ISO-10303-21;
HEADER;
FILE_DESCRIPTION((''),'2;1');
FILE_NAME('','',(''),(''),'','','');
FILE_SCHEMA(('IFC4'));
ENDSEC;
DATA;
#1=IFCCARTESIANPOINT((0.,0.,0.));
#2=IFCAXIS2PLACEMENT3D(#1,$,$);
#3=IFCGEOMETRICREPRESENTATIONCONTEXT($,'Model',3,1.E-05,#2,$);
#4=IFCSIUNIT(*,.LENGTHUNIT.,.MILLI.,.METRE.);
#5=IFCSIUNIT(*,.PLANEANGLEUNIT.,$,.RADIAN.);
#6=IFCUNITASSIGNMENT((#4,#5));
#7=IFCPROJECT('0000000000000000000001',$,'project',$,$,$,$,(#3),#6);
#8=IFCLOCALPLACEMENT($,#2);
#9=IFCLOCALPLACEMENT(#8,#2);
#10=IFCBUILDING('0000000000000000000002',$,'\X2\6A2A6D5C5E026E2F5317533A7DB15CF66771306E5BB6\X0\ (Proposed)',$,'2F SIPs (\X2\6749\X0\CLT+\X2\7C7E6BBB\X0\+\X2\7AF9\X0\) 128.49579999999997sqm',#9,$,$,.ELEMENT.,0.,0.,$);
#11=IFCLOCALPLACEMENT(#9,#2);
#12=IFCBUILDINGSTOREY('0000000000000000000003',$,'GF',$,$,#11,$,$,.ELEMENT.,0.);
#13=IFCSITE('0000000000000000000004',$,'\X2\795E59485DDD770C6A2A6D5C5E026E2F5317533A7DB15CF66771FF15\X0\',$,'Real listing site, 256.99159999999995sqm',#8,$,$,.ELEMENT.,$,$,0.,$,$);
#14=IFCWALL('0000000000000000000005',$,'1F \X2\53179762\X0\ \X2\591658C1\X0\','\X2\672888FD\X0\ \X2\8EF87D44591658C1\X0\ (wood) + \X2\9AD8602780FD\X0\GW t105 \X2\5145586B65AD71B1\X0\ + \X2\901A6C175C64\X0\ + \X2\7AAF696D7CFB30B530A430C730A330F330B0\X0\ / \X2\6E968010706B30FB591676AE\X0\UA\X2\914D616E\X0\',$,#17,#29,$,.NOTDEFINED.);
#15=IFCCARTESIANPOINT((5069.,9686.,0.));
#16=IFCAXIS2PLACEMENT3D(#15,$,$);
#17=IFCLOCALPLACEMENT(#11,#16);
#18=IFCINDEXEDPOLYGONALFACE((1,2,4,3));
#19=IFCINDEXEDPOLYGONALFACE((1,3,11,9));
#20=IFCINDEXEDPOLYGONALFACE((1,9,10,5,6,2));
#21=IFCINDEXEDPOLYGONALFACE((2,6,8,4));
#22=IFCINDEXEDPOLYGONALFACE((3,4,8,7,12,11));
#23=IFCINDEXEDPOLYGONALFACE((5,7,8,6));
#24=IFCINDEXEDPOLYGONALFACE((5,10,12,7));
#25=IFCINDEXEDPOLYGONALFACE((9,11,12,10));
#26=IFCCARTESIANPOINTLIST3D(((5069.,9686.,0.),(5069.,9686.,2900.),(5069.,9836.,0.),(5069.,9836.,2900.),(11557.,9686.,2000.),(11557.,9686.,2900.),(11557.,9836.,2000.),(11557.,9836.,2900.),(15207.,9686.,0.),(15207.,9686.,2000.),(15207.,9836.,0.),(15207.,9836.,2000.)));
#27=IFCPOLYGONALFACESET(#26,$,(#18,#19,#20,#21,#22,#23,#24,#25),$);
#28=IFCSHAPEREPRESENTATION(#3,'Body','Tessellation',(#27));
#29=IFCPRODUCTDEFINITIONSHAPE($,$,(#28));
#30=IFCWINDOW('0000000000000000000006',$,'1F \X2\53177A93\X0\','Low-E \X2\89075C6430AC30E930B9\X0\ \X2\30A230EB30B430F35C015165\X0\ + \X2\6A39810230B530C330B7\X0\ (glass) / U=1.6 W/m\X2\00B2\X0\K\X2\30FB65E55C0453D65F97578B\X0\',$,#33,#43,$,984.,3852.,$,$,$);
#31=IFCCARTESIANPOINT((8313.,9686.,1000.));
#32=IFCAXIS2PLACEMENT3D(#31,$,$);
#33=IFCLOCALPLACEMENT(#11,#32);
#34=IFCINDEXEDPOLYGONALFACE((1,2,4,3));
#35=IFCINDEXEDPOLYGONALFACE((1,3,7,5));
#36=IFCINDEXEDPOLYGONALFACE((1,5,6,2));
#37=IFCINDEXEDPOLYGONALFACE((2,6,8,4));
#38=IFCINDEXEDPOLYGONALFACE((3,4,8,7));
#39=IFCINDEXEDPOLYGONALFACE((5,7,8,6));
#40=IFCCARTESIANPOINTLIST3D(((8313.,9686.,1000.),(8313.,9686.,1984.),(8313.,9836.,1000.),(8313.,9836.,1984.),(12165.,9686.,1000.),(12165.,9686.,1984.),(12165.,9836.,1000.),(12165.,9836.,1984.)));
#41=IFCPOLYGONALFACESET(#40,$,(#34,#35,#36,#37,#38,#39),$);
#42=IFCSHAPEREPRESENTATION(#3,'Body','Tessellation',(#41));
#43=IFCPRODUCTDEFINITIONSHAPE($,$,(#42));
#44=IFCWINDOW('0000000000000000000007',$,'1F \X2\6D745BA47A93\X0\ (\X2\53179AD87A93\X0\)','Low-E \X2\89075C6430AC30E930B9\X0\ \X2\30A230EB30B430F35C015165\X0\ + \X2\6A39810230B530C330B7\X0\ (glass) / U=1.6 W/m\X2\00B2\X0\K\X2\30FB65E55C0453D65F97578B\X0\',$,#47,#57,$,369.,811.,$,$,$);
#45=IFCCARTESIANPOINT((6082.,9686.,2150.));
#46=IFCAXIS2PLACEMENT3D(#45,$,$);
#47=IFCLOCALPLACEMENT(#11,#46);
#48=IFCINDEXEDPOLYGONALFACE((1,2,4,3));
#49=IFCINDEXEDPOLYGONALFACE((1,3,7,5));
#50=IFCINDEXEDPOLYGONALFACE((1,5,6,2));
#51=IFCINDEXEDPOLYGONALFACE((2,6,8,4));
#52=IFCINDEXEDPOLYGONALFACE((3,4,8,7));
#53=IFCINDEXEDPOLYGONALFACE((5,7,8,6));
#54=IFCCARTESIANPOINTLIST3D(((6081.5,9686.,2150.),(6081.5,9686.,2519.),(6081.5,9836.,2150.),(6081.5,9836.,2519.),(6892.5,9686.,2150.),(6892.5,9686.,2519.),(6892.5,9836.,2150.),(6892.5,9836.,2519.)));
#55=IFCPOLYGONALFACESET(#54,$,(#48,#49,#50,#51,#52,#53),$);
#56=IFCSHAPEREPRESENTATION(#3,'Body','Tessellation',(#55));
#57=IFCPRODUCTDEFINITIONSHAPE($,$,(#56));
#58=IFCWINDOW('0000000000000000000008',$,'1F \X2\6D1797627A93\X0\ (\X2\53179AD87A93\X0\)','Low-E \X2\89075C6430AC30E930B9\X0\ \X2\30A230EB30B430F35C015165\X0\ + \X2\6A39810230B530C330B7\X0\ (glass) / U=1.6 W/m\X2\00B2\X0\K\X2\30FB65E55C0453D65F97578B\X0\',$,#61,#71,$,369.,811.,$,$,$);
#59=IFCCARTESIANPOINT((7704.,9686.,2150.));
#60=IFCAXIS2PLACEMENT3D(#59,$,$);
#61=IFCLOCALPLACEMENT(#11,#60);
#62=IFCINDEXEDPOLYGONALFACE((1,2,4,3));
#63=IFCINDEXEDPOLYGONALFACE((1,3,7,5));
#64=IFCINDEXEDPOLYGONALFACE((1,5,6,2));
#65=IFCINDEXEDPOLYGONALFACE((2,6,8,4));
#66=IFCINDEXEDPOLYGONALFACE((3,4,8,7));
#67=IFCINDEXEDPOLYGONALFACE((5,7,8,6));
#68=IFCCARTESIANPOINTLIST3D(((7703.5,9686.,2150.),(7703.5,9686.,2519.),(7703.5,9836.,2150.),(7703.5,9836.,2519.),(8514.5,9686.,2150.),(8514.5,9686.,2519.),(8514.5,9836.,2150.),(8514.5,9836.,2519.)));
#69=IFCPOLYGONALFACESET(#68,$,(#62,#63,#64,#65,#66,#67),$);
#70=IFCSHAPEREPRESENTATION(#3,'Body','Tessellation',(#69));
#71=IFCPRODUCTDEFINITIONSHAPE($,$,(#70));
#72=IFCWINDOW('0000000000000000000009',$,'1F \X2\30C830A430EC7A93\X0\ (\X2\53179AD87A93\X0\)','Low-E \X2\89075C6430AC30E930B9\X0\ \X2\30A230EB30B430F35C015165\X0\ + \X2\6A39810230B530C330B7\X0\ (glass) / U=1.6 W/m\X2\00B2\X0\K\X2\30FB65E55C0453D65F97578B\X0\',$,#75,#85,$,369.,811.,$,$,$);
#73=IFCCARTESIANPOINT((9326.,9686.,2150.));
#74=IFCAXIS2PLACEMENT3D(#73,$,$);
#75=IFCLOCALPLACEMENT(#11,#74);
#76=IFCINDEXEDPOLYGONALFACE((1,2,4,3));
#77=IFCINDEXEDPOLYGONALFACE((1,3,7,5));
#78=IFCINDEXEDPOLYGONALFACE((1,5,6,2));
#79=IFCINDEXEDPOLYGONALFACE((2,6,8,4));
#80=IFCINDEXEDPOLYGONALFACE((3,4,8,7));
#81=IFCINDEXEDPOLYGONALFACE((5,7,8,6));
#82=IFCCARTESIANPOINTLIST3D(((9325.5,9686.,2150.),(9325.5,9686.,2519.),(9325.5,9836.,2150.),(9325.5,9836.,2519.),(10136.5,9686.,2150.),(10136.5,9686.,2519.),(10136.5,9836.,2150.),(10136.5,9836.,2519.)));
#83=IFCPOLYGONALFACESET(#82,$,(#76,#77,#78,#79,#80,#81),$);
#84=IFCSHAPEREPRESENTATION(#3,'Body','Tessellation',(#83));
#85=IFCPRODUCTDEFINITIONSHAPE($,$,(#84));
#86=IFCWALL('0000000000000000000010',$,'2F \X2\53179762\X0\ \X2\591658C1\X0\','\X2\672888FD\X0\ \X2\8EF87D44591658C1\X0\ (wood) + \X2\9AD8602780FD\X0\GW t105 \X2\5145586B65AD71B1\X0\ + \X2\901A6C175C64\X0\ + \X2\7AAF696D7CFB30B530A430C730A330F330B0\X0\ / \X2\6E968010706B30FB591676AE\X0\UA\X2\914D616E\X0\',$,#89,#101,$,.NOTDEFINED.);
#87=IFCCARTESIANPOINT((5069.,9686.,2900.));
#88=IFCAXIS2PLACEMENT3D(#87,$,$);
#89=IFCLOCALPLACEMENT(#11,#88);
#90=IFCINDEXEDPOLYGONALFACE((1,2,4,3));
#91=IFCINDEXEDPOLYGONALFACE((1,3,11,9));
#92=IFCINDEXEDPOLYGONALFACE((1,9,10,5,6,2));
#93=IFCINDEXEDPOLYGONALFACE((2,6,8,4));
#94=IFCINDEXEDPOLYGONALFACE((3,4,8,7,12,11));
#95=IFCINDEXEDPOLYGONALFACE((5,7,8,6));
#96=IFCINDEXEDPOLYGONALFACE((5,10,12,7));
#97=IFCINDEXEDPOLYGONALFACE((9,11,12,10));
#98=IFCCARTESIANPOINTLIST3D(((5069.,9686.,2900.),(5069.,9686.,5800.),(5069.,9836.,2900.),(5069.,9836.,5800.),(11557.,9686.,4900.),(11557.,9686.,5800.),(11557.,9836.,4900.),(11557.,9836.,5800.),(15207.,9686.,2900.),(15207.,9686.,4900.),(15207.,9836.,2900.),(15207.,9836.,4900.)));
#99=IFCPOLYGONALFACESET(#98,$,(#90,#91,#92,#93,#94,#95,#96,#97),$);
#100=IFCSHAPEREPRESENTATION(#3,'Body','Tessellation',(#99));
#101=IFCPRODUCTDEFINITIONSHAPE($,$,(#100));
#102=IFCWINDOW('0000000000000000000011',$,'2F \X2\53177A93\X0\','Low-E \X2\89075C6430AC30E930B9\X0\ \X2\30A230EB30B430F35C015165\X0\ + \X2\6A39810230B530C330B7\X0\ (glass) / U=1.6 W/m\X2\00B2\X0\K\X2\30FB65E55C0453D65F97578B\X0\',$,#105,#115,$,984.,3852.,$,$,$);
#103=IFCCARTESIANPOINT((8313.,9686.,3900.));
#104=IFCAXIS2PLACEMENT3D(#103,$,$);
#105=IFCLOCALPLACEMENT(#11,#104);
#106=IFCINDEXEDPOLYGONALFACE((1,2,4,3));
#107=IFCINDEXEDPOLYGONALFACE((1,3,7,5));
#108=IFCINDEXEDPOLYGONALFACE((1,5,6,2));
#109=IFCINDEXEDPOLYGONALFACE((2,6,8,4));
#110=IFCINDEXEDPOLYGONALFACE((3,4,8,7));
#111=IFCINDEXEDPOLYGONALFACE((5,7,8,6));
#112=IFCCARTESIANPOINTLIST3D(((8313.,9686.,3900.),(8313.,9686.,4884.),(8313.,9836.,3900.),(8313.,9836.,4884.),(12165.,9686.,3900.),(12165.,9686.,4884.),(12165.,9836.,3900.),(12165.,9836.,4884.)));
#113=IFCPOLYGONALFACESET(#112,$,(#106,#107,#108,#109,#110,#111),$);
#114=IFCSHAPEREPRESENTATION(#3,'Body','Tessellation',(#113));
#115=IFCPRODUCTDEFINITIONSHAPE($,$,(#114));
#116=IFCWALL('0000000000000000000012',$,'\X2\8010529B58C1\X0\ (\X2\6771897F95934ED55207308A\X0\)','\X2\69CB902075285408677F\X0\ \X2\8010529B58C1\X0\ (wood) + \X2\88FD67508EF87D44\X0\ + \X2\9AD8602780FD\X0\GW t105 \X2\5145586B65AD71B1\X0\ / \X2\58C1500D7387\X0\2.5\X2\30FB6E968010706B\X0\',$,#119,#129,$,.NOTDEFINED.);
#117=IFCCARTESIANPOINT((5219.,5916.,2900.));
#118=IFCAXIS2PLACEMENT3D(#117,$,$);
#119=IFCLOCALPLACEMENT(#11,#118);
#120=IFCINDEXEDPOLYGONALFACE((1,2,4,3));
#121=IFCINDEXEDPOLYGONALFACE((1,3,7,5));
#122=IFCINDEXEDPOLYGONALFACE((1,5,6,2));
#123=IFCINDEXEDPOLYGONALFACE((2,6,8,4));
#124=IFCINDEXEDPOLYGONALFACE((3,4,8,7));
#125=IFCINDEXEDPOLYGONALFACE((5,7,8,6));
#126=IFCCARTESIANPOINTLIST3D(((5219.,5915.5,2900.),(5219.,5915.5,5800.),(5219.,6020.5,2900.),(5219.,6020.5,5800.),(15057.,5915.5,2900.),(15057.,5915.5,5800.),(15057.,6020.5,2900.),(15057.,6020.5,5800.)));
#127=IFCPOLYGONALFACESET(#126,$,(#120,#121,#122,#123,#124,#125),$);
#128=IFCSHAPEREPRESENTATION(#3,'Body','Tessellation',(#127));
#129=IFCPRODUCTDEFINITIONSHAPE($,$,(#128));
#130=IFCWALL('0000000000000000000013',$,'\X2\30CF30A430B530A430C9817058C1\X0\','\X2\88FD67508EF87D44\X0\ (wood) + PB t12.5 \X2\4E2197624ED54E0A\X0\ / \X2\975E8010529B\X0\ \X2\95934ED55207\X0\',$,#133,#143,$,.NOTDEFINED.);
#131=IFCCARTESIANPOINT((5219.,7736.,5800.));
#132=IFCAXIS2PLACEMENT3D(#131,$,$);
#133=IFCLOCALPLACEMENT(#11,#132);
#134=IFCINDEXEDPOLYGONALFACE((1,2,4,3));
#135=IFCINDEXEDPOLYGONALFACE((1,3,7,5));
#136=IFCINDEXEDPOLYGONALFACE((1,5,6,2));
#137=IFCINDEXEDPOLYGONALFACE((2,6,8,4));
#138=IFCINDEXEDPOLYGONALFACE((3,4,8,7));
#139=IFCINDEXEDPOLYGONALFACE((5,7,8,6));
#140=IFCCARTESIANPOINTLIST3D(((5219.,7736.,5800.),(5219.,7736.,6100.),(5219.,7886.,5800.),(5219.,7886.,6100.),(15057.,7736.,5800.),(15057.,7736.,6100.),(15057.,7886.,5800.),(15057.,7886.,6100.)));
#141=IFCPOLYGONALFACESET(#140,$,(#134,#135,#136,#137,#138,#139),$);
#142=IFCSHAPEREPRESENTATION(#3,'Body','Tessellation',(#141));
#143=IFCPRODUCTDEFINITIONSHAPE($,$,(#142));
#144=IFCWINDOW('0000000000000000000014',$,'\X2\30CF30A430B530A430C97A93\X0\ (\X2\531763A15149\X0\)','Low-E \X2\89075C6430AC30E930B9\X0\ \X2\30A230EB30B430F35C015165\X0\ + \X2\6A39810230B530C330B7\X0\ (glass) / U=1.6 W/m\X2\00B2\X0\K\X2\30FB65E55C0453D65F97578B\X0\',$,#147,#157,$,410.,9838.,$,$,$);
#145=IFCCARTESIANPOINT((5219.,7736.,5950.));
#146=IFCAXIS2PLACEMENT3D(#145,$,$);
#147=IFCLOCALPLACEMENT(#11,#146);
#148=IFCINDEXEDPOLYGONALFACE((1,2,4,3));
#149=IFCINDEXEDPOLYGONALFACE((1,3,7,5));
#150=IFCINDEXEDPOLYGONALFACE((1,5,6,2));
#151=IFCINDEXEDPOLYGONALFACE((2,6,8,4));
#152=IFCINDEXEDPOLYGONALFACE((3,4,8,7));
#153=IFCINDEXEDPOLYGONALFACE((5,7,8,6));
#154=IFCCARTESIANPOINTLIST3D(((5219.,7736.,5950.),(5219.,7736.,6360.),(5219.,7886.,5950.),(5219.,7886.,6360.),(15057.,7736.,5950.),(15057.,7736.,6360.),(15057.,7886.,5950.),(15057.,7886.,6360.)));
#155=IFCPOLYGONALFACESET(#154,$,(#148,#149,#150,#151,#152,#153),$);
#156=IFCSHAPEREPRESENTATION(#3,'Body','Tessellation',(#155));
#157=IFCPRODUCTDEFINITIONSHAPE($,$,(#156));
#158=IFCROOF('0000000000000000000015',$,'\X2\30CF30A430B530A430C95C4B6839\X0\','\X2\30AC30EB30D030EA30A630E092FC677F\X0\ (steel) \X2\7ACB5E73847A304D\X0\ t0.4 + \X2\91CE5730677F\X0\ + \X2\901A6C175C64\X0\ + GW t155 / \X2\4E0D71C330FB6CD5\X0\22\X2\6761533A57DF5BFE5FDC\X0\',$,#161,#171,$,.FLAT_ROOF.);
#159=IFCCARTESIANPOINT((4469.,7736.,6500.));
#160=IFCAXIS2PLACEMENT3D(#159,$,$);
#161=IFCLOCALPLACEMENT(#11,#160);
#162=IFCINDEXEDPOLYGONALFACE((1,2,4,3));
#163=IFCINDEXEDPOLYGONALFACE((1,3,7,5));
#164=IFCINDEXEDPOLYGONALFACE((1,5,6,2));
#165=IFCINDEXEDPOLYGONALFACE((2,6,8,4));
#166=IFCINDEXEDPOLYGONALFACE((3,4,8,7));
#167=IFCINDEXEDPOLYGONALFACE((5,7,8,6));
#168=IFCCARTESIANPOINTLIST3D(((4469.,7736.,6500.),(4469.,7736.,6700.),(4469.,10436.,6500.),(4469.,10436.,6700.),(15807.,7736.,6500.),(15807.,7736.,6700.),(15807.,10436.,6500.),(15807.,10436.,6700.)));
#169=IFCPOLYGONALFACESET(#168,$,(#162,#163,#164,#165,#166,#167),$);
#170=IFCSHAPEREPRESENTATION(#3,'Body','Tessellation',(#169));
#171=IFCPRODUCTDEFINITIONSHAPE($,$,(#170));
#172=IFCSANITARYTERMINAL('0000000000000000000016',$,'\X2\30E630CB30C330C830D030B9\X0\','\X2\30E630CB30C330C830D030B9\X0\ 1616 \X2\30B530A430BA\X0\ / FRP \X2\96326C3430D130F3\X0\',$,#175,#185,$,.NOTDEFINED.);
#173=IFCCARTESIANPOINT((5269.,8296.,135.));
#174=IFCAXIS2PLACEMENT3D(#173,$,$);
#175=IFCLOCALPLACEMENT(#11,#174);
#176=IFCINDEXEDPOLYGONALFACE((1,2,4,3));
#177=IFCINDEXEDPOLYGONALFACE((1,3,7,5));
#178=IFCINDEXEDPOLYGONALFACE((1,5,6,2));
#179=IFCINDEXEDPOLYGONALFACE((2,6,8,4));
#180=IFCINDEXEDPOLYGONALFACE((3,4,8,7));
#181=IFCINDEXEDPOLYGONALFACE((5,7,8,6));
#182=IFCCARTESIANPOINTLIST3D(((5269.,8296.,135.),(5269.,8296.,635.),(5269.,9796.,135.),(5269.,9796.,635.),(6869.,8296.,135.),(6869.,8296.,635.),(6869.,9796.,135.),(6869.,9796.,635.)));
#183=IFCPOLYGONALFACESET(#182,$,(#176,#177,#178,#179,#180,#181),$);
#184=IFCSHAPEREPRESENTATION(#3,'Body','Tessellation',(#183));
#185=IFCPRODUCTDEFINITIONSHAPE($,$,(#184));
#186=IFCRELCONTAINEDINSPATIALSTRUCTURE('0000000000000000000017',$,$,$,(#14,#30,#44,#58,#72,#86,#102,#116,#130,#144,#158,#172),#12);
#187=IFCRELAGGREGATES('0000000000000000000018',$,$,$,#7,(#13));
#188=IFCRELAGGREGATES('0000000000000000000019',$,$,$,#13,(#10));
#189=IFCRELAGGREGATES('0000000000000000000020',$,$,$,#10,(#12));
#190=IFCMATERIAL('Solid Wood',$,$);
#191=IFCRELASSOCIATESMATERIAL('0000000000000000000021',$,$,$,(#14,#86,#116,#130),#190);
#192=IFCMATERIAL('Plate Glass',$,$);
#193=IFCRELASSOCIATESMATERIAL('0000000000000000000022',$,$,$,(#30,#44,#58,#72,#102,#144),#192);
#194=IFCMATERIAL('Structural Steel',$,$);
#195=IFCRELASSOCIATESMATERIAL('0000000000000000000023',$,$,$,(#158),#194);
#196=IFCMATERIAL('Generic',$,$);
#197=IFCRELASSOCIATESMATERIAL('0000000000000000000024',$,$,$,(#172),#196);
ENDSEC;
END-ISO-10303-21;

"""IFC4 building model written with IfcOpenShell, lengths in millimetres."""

from ifc_helpers import new_model, si_unit, frame, frame_2d, origin, place, context, project, spatial, rectangle, extrude, material, element, fill, save


model = new_model("IFC4")

# Units and contexts
model_context = context("Model", 3, precision=1e-05, world=origin())
ifc_project = project(units=[si_unit("LENGTHUNIT", "METRE", prefix="MILLI"), si_unit("PLANEANGLEUNIT", "RADIAN")], contexts=[model_context])

# Site, building, storey
site_placement = place(None, origin())
site = spatial("IfcSite", under=ifc_project, at=site_placement, Name="神奈川県横浜市港北区綱島東５", ObjectType="Real listing site, 256.99159999999995sqm", CompositionType="ELEMENT", RefElevation=0.0)
building_placement = place(site_placement, origin())
building = spatial("IfcBuilding", under=site, at=building_placement, Name="横浜市港北区綱島東の家 (Proposed)", ObjectType="2F SIPs (杉CLT+籾殻+竹) 128.49579999999997sqm", CompositionType="ELEMENT", ElevationOfRefHeight=0.0, ElevationOfTerrain=0.0)
storey_placement = place(building_placement, origin())
storey = spatial("IfcBuildingStorey", under=building, at=storey_placement, Name="GF", CompositionType="ELEMENT", Elevation=0.0)

# Wall, openings, windows
ifc_material_1 = material(Name="Solid Wood")
wall_1_placement = place(storey_placement, frame((5069.0, 9686.0, 0.0)))
wall_1 = element("IfcWall", 1, at=wall_1_placement, inside=storey, material=ifc_material_1, Name="1F 北面 外壁", Description="木製 軸組外壁 (wood) + 高性能GW t105 充填断熱 + 通気層 + 窯業系サイディング / 準耐火・外皮UA配慮", PredefinedType="NOTDEFINED", context=model_context, shape_type="SweptSolid", body=[
    extrude(rectangle(XDim=10138.0, YDim=150.0, at=frame_2d((5069.0, 75.0))), frame((5069.0, 9686.0, 0.0)), (0.0, 0.0, 1.0), 2900.0),
])
opening_1_placement = place(storey_placement, frame((8313.0, 9686.0, 1000.0)))
opening_1 = element("IfcOpeningElement", 2, at=opening_1_placement, cuts=wall_1, PredefinedType="NOTDEFINED", context=model_context, shape_type="SweptSolid", body=[
    extrude(rectangle(XDim=3852.0, YDim=150.0, at=frame_2d((1926.0, 75.0))), frame((8313.0, 9686.0, 1000.0)), (0.0, 0.0, 1.0), 984.0),
])
opening_2_placement = place(storey_placement, frame((6082.0, 9686.0, 2150.0)))
opening_2 = element("IfcOpeningElement", 3, at=opening_2_placement, cuts=wall_1, PredefinedType="NOTDEFINED", context=model_context, shape_type="SweptSolid", body=[
    extrude(rectangle(XDim=811.0, YDim=150.0, at=frame_2d((405.0, 75.0))), frame((6082.0, 9686.0, 2150.0)), (0.0, 0.0, 1.0), 369.0),
])
opening_3_placement = place(storey_placement, frame((7704.0, 9686.0, 2150.0)))
opening_3 = element("IfcOpeningElement", 4, at=opening_3_placement, cuts=wall_1, PredefinedType="NOTDEFINED", context=model_context, shape_type="SweptSolid", body=[
    extrude(rectangle(XDim=811.0, YDim=150.0, at=frame_2d((405.0, 75.0))), frame((7704.0, 9686.0, 2150.0)), (0.0, 0.0, 1.0), 369.0),
])
opening_4_placement = place(storey_placement, frame((9326.0, 9686.0, 2150.0)))
opening_4 = element("IfcOpeningElement", 5, at=opening_4_placement, cuts=wall_1, PredefinedType="NOTDEFINED", context=model_context, shape_type="SweptSolid", body=[
    extrude(rectangle(XDim=811.0, YDim=150.0, at=frame_2d((405.0, 75.0))), frame((9326.0, 9686.0, 2150.0)), (0.0, 0.0, 1.0), 369.0),
])
ifc_material_2 = material(Name="Plate Glass")
window_1_placement = place(storey_placement, frame((8313.0, 9686.0, 1000.0)))
window_1 = element("IfcWindow", 6, at=window_1_placement, inside=storey, material=ifc_material_2, Name="1F 北窓", Description="Low-E 複層ガラス アルゴン封入 + 樹脂サッシ (glass) / U=1.6 W/m²K・日射取得型", OverallHeight=984.0, OverallWidth=3852.0, context=model_context, shape_type="SweptSolid", body=[
    extrude(rectangle(XDim=3852.0, YDim=150.0, at=frame_2d((1926.0, 75.0))), frame((8313.0, 9686.0, 1000.0)), (0.0, 0.0, 1.0), 984.0),
])
fill(opening_1, window_1)
window_2_placement = place(storey_placement, frame((6082.0, 9686.0, 2150.0)))
window_2 = element("IfcWindow", 7, at=window_2_placement, inside=storey, material=ifc_material_2, Name="1F 浴室窓 (北高窓)", Description="Low-E 複層ガラス アルゴン封入 + 樹脂サッシ (glass) / U=1.6 W/m²K・日射取得型", OverallHeight=369.0, OverallWidth=811.0, context=model_context, shape_type="SweptSolid", body=[
    extrude(rectangle(XDim=811.0, YDim=150.0, at=frame_2d((405.0, 75.0))), frame((6082.0, 9686.0, 2150.0)), (0.0, 0.0, 1.0), 369.0),
])
fill(opening_2, window_2)
window_3_placement = place(storey_placement, frame((7704.0, 9686.0, 2150.0)))
window_3 = element("IfcWindow", 8, at=window_3_placement, inside=storey, material=ifc_material_2, Name="1F 洗面窓 (北高窓)", Description="Low-E 複層ガラス アルゴン封入 + 樹脂サッシ (glass) / U=1.6 W/m²K・日射取得型", OverallHeight=369.0, OverallWidth=811.0, context=model_context, shape_type="SweptSolid", body=[
    extrude(rectangle(XDim=811.0, YDim=150.0, at=frame_2d((405.0, 75.0))), frame((7704.0, 9686.0, 2150.0)), (0.0, 0.0, 1.0), 369.0),
])
fill(opening_3, window_3)
window_4_placement = place(storey_placement, frame((9326.0, 9686.0, 2150.0)))
window_4 = element("IfcWindow", 9, at=window_4_placement, inside=storey, material=ifc_material_2, Name="1F トイレ窓 (北高窓)", Description="Low-E 複層ガラス アルゴン封入 + 樹脂サッシ (glass) / U=1.6 W/m²K・日射取得型", OverallHeight=369.0, OverallWidth=811.0, context=model_context, shape_type="SweptSolid", body=[
    extrude(rectangle(XDim=811.0, YDim=150.0, at=frame_2d((405.0, 75.0))), frame((9326.0, 9686.0, 2150.0)), (0.0, 0.0, 1.0), 369.0),
])
fill(opening_4, window_4)

# Wall, opening, window
wall_2_placement = place(storey_placement, frame((5069.0, 9686.0, 2900.0)))
wall_2 = element("IfcWall", 10, at=wall_2_placement, inside=storey, material=ifc_material_1, Name="2F 北面 外壁", Description="木製 軸組外壁 (wood) + 高性能GW t105 充填断熱 + 通気層 + 窯業系サイディング / 準耐火・外皮UA配慮", PredefinedType="NOTDEFINED", context=model_context, shape_type="SweptSolid", body=[
    extrude(rectangle(XDim=10138.0, YDim=150.0, at=frame_2d((5069.0, 75.0))), frame((5069.0, 9686.0, 2900.0)), (0.0, 0.0, 1.0), 2900.0),
])
opening_5_placement = place(storey_placement, frame((8313.0, 9686.0, 3900.0)))
opening_5 = element("IfcOpeningElement", 11, at=opening_5_placement, cuts=wall_2, PredefinedType="NOTDEFINED", context=model_context, shape_type="SweptSolid", body=[
    extrude(rectangle(XDim=3852.0, YDim=150.0, at=frame_2d((1926.0, 75.0))), frame((8313.0, 9686.0, 3900.0)), (0.0, 0.0, 1.0), 984.0),
])
window_5_placement = place(storey_placement, frame((8313.0, 9686.0, 3900.0)))
window_5 = element("IfcWindow", 12, at=window_5_placement, inside=storey, material=ifc_material_2, Name="2F 北窓", Description="Low-E 複層ガラス アルゴン封入 + 樹脂サッシ (glass) / U=1.6 W/m²K・日射取得型", OverallHeight=984.0, OverallWidth=3852.0, context=model_context, shape_type="SweptSolid", body=[
    extrude(rectangle(XDim=3852.0, YDim=150.0, at=frame_2d((1926.0, 75.0))), frame((8313.0, 9686.0, 3900.0)), (0.0, 0.0, 1.0), 984.0),
])
fill(opening_5, window_5)

# Wall
wall_3_placement = place(storey_placement, frame((5219.0, 5916.0, 2900.0)))
element("IfcWall", 13, at=wall_3_placement, inside=storey, material=ifc_material_1, Name="耐力壁 (東西間仕切り)", Description="構造用合板 耐力壁 (wood) + 製材軸組 + 高性能GW t105 充填断熱 / 壁倍率2.5・準耐火", PredefinedType="NOTDEFINED", context=model_context, shape_type="SweptSolid", body=[
    extrude(rectangle(XDim=9838.0, YDim=105.0, at=frame_2d((4919.0, 52.0))), frame((5219.0, 5916.0, 2900.0)), (0.0, 0.0, 1.0), 2900.0),
])

# Wall, opening, window
wall_4_placement = place(storey_placement, frame((5219.0, 7736.0, 5800.0)))
wall_4 = element("IfcWall", 14, at=wall_4_placement, inside=storey, material=ifc_material_1, Name="ハイサイド腰壁", Description="製材軸組 (wood) + PB t12.5 両面仕上 / 非耐力 間仕切", PredefinedType="NOTDEFINED", context=model_context, shape_type="SweptSolid", body=[
    extrude(rectangle(XDim=9838.0, YDim=150.0, at=frame_2d((4919.0, 75.0))), frame((5219.0, 7736.0, 5800.0)), (0.0, 0.0, 1.0), 700.0),
])
opening_6_placement = place(storey_placement, frame((5219.0, 7736.0, 5950.0)))
opening_6 = element("IfcOpeningElement", 15, at=opening_6_placement, cuts=wall_4, PredefinedType="NOTDEFINED", context=model_context, shape_type="SweptSolid", body=[
    extrude(rectangle(XDim=9838.0, YDim=150.0, at=frame_2d((4919.0, 75.0))), frame((5219.0, 7736.0, 5950.0)), (0.0, 0.0, 1.0), 410.0),
])
window_6_placement = place(storey_placement, frame((5219.0, 7736.0, 5950.0)))
window_6 = element("IfcWindow", 16, at=window_6_placement, inside=storey, material=ifc_material_2, Name="ハイサイド窓 (北採光)", Description="Low-E 複層ガラス アルゴン封入 + 樹脂サッシ (glass) / U=1.6 W/m²K・日射取得型", OverallHeight=410.0, OverallWidth=9838.0, context=model_context, shape_type="SweptSolid", body=[
    extrude(rectangle(XDim=9838.0, YDim=150.0, at=frame_2d((4919.0, 75.0))), frame((5219.0, 7736.0, 5950.0)), (0.0, 0.0, 1.0), 410.0),
])
fill(opening_6, window_6)

# Roof
ifc_material_3 = material(Name="Structural Steel")
roof_placement = place(storey_placement, frame((4469.0, 7736.0, 6500.0)))
element("IfcRoof", 17, at=roof_placement, inside=storey, material=ifc_material_3, Name="ハイサイド屋根", Description="ガルバリウム鋼板 (steel) 立平葺き t0.4 + 野地板 + 通気層 + GW t155 / 不燃・法22条区域対応", PredefinedType="FLAT_ROOF", context=model_context, shape_type="SweptSolid", body=[
    extrude(rectangle(XDim=11338.0, YDim=2700.0, at=frame_2d((5669.0, 1350.0))), frame((4469.0, 7736.0, 6500.0)), (0.0, 0.0, 1.0), 200.0),
])

# Sanitary terminal
ifc_material_4 = material(Name="Generic")
sanitary_terminal_placement = place(storey_placement, frame((5269.0, 8296.0, 135.0)))
element("IfcSanitaryTerminal", 18, at=sanitary_terminal_placement, inside=storey, material=ifc_material_4, Name="ユニットバス", Description="ユニットバス 1616 サイズ / FRP 防水パン", PredefinedType="NOTDEFINED", context=model_context, shape_type="SweptSolid", body=[
    extrude(rectangle(XDim=1600.0, YDim=1500.0, at=frame_2d((800.0, 750.0))), frame((5269.0, 8296.0, 135.0)), (0.0, 0.0, 1.0), 500.0),
])

save(model, "model.ifc")
